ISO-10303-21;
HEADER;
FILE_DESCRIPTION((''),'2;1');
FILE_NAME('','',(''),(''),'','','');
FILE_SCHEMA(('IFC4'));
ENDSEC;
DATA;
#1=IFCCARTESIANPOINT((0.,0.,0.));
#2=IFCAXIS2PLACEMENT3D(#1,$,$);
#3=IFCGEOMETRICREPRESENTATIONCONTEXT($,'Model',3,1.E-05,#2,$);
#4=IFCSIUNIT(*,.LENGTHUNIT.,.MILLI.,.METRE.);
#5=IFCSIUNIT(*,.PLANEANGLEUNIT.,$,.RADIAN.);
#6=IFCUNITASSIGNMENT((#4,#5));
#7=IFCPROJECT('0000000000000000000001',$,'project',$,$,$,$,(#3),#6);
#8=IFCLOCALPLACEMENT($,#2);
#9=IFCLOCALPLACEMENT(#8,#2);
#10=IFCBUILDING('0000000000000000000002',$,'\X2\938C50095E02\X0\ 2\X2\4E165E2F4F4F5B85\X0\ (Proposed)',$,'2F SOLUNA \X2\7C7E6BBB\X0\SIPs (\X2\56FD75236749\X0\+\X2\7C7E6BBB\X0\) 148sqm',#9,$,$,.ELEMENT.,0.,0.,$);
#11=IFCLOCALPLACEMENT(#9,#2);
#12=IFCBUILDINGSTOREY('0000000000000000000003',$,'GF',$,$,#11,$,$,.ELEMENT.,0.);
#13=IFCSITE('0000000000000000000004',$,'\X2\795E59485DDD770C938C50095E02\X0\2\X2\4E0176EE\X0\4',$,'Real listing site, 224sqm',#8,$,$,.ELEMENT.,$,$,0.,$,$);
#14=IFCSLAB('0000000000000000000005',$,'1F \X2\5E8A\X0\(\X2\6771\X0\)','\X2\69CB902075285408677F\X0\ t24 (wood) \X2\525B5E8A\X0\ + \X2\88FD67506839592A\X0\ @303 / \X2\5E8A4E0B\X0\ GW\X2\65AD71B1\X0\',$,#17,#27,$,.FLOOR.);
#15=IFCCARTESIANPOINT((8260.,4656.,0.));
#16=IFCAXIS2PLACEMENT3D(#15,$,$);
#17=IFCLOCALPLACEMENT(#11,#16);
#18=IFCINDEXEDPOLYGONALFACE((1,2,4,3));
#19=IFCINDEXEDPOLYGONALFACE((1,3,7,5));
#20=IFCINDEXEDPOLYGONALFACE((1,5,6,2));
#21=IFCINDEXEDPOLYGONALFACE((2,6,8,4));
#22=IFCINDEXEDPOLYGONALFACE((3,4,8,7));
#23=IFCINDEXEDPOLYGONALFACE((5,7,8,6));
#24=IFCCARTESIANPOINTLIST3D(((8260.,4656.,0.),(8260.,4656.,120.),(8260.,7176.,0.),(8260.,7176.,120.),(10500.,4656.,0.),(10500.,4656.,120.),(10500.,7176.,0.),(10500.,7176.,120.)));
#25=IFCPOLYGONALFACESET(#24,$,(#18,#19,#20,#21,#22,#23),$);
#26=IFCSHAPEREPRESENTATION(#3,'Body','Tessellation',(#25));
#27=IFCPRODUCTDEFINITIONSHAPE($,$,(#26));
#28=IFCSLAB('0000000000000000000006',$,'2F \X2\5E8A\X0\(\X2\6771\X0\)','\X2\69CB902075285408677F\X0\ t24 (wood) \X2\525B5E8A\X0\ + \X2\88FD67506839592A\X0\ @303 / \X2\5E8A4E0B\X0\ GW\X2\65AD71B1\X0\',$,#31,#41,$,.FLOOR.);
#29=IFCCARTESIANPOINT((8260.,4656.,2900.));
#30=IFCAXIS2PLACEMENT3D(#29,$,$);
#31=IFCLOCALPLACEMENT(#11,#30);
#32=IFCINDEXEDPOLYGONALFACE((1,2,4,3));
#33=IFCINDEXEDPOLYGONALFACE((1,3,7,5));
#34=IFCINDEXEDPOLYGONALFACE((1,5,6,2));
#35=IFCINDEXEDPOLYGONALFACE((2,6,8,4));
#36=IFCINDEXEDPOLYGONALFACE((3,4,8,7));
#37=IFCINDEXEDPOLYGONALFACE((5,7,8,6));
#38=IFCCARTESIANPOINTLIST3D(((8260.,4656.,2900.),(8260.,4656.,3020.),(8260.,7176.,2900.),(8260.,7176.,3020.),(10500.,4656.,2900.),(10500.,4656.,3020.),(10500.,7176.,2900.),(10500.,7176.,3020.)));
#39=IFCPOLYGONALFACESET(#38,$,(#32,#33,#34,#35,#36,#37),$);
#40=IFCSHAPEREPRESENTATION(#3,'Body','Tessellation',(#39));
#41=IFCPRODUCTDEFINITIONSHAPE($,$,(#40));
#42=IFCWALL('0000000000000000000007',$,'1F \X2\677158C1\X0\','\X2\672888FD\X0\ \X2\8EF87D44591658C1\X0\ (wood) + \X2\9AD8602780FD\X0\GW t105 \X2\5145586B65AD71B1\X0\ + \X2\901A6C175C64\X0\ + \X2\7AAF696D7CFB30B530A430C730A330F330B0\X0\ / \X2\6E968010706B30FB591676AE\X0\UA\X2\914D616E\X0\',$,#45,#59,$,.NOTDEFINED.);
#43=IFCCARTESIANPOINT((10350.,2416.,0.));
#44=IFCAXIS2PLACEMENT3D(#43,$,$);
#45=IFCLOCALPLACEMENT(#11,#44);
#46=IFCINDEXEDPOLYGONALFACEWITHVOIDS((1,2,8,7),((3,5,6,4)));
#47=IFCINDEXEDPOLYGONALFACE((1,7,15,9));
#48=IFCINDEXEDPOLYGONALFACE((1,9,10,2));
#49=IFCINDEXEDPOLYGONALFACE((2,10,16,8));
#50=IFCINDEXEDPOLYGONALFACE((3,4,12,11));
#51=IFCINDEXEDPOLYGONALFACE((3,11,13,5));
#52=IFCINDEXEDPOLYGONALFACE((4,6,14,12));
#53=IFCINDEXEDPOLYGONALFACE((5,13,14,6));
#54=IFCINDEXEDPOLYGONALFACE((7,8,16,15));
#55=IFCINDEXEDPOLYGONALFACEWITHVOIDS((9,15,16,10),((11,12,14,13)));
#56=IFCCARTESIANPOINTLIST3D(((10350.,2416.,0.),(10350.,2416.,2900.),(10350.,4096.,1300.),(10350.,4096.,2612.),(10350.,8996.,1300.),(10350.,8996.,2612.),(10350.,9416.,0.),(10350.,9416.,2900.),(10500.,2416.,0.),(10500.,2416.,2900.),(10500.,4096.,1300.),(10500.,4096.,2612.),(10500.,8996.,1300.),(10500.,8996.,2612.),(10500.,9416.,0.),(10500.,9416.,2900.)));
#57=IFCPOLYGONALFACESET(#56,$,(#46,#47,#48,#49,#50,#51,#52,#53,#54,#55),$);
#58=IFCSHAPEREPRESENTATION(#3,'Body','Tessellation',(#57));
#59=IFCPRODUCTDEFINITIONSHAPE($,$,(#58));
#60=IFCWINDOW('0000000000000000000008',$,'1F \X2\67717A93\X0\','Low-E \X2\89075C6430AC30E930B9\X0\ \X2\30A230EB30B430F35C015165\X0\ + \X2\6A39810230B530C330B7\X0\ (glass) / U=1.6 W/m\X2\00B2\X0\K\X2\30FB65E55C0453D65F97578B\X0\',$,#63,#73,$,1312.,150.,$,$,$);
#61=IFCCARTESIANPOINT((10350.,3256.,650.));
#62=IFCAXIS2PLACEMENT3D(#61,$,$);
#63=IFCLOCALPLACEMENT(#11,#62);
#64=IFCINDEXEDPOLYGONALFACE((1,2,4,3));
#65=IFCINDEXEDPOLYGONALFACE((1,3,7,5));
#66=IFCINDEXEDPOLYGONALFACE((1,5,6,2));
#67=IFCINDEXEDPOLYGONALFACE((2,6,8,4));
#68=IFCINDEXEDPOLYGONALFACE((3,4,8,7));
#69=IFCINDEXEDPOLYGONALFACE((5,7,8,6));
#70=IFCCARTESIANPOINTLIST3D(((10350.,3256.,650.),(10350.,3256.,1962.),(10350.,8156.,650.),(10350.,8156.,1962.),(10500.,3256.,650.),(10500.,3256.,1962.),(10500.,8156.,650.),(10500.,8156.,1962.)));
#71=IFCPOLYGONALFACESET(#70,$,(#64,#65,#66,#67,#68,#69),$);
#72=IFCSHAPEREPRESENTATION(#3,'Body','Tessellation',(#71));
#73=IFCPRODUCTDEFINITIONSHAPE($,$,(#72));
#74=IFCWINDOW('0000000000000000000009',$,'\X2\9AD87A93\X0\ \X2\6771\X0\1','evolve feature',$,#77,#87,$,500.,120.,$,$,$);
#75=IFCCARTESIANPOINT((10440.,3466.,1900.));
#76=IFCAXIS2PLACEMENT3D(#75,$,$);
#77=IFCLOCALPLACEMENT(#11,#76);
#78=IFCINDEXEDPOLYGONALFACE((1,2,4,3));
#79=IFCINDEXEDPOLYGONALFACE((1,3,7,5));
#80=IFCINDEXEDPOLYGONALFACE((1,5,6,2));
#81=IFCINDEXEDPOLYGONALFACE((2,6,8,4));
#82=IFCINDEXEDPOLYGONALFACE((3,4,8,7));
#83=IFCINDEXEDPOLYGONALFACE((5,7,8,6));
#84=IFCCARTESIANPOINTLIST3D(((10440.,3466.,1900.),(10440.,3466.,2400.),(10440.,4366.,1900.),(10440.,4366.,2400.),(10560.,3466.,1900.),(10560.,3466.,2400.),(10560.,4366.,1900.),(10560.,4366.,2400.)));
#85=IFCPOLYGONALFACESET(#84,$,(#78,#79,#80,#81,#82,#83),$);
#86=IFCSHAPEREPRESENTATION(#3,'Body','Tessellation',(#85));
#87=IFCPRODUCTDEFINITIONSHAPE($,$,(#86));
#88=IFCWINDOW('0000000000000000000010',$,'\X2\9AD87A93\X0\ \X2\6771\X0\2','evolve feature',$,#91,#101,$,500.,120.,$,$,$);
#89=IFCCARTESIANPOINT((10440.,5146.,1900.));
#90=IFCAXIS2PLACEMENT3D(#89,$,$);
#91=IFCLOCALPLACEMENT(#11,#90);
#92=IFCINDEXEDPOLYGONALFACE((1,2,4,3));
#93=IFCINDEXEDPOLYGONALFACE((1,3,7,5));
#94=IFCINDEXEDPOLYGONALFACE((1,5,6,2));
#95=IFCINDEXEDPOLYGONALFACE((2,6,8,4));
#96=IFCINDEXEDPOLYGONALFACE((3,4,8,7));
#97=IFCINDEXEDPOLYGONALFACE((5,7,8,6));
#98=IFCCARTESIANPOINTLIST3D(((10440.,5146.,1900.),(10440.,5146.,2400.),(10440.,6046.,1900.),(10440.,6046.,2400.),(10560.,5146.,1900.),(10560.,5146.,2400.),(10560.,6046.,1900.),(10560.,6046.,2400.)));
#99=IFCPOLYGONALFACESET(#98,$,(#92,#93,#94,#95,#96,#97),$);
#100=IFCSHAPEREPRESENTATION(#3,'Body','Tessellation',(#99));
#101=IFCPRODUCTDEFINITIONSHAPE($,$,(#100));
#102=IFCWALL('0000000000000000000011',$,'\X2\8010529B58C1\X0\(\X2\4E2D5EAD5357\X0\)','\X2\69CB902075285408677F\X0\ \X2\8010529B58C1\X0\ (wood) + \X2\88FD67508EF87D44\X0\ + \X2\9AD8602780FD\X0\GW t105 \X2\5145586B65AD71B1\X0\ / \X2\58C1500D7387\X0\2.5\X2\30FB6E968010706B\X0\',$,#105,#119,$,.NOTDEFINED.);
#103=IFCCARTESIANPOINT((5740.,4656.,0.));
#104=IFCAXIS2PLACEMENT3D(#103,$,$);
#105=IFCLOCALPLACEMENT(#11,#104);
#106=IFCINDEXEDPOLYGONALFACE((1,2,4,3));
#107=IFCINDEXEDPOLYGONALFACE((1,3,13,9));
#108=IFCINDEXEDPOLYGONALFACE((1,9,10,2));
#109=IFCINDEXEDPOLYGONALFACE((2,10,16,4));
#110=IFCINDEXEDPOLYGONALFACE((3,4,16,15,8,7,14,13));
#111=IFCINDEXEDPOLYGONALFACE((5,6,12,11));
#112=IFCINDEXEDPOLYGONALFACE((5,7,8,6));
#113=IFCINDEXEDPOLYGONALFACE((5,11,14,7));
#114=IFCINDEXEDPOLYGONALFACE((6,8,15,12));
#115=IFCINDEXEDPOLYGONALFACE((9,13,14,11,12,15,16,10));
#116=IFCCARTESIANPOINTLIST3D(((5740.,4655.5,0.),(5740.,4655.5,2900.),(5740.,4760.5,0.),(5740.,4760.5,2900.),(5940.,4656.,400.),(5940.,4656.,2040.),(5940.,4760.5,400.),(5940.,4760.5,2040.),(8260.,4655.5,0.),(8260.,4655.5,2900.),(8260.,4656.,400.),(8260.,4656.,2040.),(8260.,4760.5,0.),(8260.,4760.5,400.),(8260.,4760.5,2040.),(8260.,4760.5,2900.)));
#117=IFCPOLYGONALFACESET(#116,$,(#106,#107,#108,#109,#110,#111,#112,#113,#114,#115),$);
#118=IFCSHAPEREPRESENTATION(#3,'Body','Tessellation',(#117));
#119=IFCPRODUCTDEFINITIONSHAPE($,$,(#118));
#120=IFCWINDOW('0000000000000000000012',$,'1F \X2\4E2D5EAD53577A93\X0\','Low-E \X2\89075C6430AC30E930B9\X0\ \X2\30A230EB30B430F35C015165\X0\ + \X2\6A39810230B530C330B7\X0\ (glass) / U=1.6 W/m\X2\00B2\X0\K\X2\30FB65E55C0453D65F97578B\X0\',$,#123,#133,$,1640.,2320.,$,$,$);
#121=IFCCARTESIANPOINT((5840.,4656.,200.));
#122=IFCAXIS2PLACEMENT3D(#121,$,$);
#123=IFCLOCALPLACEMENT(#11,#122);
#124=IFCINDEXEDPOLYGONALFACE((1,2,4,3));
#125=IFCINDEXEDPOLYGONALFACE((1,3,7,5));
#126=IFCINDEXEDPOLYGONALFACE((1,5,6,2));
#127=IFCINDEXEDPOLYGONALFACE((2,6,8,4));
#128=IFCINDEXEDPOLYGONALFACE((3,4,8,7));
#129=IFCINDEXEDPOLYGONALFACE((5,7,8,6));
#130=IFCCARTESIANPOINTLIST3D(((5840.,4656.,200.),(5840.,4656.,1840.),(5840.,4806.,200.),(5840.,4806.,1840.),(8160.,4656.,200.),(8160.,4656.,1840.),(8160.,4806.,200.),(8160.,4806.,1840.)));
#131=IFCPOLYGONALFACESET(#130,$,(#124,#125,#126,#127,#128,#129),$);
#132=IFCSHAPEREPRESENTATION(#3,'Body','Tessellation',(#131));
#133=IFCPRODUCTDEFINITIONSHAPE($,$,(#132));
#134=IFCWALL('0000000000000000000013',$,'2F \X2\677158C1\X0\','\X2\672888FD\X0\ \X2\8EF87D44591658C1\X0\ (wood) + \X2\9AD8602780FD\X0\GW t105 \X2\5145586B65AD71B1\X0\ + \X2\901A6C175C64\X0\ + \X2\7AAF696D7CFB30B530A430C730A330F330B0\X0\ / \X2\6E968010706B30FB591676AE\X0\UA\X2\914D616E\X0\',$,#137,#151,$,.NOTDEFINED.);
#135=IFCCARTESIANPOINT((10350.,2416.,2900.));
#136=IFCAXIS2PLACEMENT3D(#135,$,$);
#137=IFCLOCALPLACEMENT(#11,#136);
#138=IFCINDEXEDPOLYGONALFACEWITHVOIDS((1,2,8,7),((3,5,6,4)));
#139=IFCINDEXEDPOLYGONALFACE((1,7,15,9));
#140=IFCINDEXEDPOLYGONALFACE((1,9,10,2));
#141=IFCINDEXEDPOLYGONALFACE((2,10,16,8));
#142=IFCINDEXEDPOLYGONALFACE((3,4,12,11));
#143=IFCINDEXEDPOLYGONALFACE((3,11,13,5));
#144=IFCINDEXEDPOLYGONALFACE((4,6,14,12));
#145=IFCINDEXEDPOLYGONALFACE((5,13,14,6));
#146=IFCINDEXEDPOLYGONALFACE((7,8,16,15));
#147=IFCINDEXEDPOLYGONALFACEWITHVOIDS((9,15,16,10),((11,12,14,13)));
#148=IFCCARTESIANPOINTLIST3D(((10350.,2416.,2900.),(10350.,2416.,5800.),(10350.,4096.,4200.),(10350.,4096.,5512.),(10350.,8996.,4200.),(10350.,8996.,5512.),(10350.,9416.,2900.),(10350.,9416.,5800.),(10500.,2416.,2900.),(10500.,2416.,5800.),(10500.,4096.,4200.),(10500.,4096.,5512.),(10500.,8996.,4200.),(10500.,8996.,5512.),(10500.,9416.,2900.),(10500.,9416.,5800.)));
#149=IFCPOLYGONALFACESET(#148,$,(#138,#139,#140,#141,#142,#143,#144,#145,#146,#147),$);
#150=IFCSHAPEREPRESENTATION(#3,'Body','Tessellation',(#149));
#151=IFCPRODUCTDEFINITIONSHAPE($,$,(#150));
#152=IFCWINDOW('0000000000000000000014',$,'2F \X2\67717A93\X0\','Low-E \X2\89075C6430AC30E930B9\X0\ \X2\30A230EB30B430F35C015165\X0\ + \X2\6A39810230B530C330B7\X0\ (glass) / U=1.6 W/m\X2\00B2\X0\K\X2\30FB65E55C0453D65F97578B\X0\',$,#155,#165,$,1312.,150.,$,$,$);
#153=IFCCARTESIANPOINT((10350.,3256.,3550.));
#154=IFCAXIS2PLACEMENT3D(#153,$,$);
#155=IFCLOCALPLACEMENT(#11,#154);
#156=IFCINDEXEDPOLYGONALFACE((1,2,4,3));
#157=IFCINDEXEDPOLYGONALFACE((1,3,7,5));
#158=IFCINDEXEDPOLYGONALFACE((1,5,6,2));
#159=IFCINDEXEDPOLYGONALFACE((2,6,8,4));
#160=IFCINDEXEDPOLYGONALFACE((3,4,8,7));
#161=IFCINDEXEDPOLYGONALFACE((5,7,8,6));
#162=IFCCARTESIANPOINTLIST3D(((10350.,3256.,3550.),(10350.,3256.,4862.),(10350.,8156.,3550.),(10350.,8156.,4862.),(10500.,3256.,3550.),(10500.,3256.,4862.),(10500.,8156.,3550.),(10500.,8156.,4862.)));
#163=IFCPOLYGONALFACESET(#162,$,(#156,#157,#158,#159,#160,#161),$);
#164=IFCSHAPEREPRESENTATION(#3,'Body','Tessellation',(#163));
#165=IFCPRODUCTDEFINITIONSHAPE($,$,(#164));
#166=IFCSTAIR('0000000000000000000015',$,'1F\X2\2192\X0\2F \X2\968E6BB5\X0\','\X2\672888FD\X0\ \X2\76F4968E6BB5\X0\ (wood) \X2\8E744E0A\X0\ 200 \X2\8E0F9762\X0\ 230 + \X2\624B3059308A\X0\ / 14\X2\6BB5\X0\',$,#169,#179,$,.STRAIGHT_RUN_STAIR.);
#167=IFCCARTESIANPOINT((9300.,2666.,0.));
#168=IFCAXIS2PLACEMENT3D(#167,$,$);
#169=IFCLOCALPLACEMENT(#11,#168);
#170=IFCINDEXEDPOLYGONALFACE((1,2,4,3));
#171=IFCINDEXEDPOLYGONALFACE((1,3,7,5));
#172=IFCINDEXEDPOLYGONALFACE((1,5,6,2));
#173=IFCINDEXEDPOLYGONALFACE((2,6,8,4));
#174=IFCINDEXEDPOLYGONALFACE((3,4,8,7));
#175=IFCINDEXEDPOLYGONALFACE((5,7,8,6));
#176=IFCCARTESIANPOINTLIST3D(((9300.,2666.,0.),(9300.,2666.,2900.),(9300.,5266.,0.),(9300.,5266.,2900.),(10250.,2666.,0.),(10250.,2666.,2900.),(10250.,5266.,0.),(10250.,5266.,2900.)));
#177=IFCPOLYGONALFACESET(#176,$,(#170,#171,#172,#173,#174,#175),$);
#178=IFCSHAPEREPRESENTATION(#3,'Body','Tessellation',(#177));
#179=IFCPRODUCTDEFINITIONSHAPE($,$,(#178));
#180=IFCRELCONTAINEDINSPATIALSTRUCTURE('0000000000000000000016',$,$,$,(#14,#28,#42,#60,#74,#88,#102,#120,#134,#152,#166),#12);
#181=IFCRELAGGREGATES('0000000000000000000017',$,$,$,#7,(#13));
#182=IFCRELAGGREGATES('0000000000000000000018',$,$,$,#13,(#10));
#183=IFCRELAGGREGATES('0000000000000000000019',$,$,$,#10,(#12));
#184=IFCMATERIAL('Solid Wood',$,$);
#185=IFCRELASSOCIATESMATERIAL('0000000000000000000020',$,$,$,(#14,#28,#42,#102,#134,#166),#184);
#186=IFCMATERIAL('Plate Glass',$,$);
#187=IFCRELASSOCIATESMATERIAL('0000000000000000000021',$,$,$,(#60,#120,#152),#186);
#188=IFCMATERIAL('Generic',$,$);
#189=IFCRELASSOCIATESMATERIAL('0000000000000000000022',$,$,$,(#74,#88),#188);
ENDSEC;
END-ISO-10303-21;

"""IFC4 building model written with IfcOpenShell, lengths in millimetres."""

from ifc_helpers import new_model, si_unit, frame, frame_2d, origin, place, context, project, spatial, rectangle, extrude, material, element, fill, save


model = new_model("IFC4")

# Units and contexts
model_context = context("Model", 3, precision=1e-05, world=origin())
ifc_project = project(units=[si_unit("LENGTHUNIT", "METRE", prefix="MILLI"), si_unit("PLANEANGLEUNIT", "RADIAN")], contexts=[model_context])

# Site, building, storey
site_placement = place(None, origin())
site = spatial("IfcSite", under=ifc_project, at=site_placement, Name="神奈川県鎌倉市2丁目4", ObjectType="Real listing site, 224sqm", CompositionType="ELEMENT", RefElevation=0.0)
building_placement = place(site_placement, origin())
building = spatial("IfcBuilding", under=site, at=building_placement, Name="鎌倉市 2世帯住宅 (Proposed)", ObjectType="2F SOLUNA 籾殻SIPs (国産杉+籾殻) 148sqm", CompositionType="ELEMENT", ElevationOfRefHeight=0.0, ElevationOfTerrain=0.0)
storey_placement = place(building_placement, origin())
storey = spatial("IfcBuildingStorey", under=building, at=storey_placement, Name="GF", CompositionType="ELEMENT", Elevation=0.0)

# Slabs
ifc_material_1 = material(Name="Solid Wood")
slab_1_placement = place(storey_placement, frame((8260.0, 4656.0, 0.0)))
element("IfcSlab", 1, at=slab_1_placement, inside=storey, material=ifc_material_1, Name="1F 床(東)", Description="構造用合板 t24 (wood) 剛床 + 製材根太 @303 / 床下 GW断熱", PredefinedType="FLOOR", context=model_context, shape_type="SweptSolid", body=[
    extrude(rectangle(XDim=2240.0, YDim=2520.0, at=frame_2d((1120.0, 1260.0))), frame((8260.0, 4656.0, 0.0)), (0.0, 0.0, 1.0), 120.0),
])
slab_2_placement = place(storey_placement, frame((8260.0, 4656.0, 2900.0)))
element("IfcSlab", 2, at=slab_2_placement, inside=storey, material=ifc_material_1, Name="2F 床(東)", Description="構造用合板 t24 (wood) 剛床 + 製材根太 @303 / 床下 GW断熱", PredefinedType="FLOOR", context=model_context, shape_type="SweptSolid", body=[
    extrude(rectangle(XDim=2240.0, YDim=2520.0, at=frame_2d((1120.0, 1260.0))), frame((8260.0, 4656.0, 2900.0)), (0.0, 0.0, 1.0), 120.0),
])

# Wall, openings, windows
wall_1_placement = place(storey_placement, frame((10350.0, 2416.0, 0.0)))
wall_1 = element("IfcWall", 3, at=wall_1_placement, inside=storey, material=ifc_material_1, Name="1F 東壁", Description="木製 軸組外壁 (wood) + 高性能GW t105 充填断熱 + 通気層 + 窯業系サイディング / 準耐火・外皮UA配慮", PredefinedType="NOTDEFINED", context=model_context, shape_type="SweptSolid", body=[
    extrude(rectangle(XDim=150.0, YDim=7000.0, at=frame_2d((75.0, 3500.0))), frame((10350.0, 2416.0, 0.0)), (0.0, 0.0, 1.0), 2900.0),
])
opening_1_placement = place(storey_placement, frame((10350.0, 3256.0, 650.0)))
opening_1 = element("IfcOpeningElement", 4, at=opening_1_placement, cuts=wall_1, PredefinedType="NOTDEFINED", context=model_context, shape_type="SweptSolid", body=[
    extrude(rectangle(XDim=150.0, YDim=4900.0, at=frame_2d((75.0, 2450.0))), frame((10350.0, 3256.0, 650.0)), (0.0, 0.0, 1.0), 1312.0),
])
opening_2_placement = place(storey_placement, frame((10440.0, 3466.0, 1900.0)))
opening_2 = element("IfcOpeningElement", 5, at=opening_2_placement, cuts=wall_1, PredefinedType="NOTDEFINED", context=model_context, shape_type="SweptSolid", body=[
    extrude(rectangle(XDim=120.0, YDim=900.0, at=frame_2d((60.0, 450.0))), frame((10440.0, 3466.0, 1900.0)), (0.0, 0.0, 1.0), 500.0),
])
opening_3_placement = place(storey_placement, frame((10440.0, 5146.0, 1900.0)))
opening_3 = element("IfcOpeningElement", 6, at=opening_3_placement, cuts=wall_1, PredefinedType="NOTDEFINED", context=model_context, shape_type="SweptSolid", body=[
    extrude(rectangle(XDim=120.0, YDim=900.0, at=frame_2d((60.0, 450.0))), frame((10440.0, 5146.0, 1900.0)), (0.0, 0.0, 1.0), 500.0),
])
ifc_material_2 = material(Name="Plate Glass")
window_1_placement = place(storey_placement, frame((10350.0, 3256.0, 650.0)))
window_1 = element("IfcWindow", 7, at=window_1_placement, inside=storey, material=ifc_material_2, Name="1F 東窓", Description="Low-E 複層ガラス アルゴン封入 + 樹脂サッシ (glass) / U=1.6 W/m²K・日射取得型", OverallHeight=1312.0, OverallWidth=150.0, context=model_context, shape_type="SweptSolid", body=[
    extrude(rectangle(XDim=150.0, YDim=4900.0, at=frame_2d((75.0, 2450.0))), frame((10350.0, 3256.0, 650.0)), (0.0, 0.0, 1.0), 1312.0),
])
fill(opening_1, window_1)
ifc_material_3 = material(Name="Generic")
window_2_placement = place(storey_placement, frame((10440.0, 3466.0, 1900.0)))
window_2 = element("IfcWindow", 8, at=window_2_placement, inside=storey, material=ifc_material_3, Name="高窓 東1", Description="evolve feature", OverallHeight=500.0, OverallWidth=120.0, context=model_context, shape_type="SweptSolid", body=[
    extrude(rectangle(XDim=120.0, YDim=900.0, at=frame_2d((60.0, 450.0))), frame((10440.0, 3466.0, 1900.0)), (0.0, 0.0, 1.0), 500.0),
])
fill(opening_2, window_2)
window_3_placement = place(storey_placement, frame((10440.0, 5146.0, 1900.0)))
window_3 = element("IfcWindow", 9, at=window_3_placement, inside=storey, material=ifc_material_3, Name="高窓 東2", Description="evolve feature", OverallHeight=500.0, OverallWidth=120.0, context=model_context, shape_type="SweptSolid", body=[
    extrude(rectangle(XDim=120.0, YDim=900.0, at=frame_2d((60.0, 450.0))), frame((10440.0, 5146.0, 1900.0)), (0.0, 0.0, 1.0), 500.0),
])
fill(opening_3, window_3)

# Wall, opening, window
wall_2_placement = place(storey_placement, frame((5740.0, 4656.0, 0.0)))
wall_2 = element("IfcWall", 10, at=wall_2_placement, inside=storey, material=ifc_material_1, Name="耐力壁(中庭南)", Description="構造用合板 耐力壁 (wood) + 製材軸組 + 高性能GW t105 充填断熱 / 壁倍率2.5・準耐火", PredefinedType="NOTDEFINED", context=model_context, shape_type="SweptSolid", body=[
    extrude(rectangle(XDim=2520.0, YDim=105.0, at=frame_2d((1260.0, 52.0))), frame((5740.0, 4656.0, 0.0)), (0.0, 0.0, 1.0), 2900.0),
])
opening_4_placement = place(storey_placement, frame((5840.0, 4656.0, 200.0)))
opening_4 = element("IfcOpeningElement", 11, at=opening_4_placement, cuts=wall_2, PredefinedType="NOTDEFINED", context=model_context, shape_type="SweptSolid", body=[
    extrude(rectangle(XDim=2320.0, YDim=150.0, at=frame_2d((1160.0, 75.0))), frame((5840.0, 4656.0, 200.0)), (0.0, 0.0, 1.0), 1640.0),
])
window_4_placement = place(storey_placement, frame((5840.0, 4656.0, 200.0)))
window_4 = element("IfcWindow", 12, at=window_4_placement, inside=storey, material=ifc_material_2, Name="1F 中庭南窓", Description="Low-E 複層ガラス アルゴン封入 + 樹脂サッシ (glass) / U=1.6 W/m²K・日射取得型", OverallHeight=1640.0, OverallWidth=2320.0, context=model_context, shape_type="SweptSolid", body=[
    extrude(rectangle(XDim=2320.0, YDim=150.0, at=frame_2d((1160.0, 75.0))), frame((5840.0, 4656.0, 200.0)), (0.0, 0.0, 1.0), 1640.0),
])
fill(opening_4, window_4)

# Wall, opening, window
wall_3_placement = place(storey_placement, frame((10350.0, 2416.0, 2900.0)))
wall_3 = element("IfcWall", 13, at=wall_3_placement, inside=storey, material=ifc_material_1, Name="2F 東壁", Description="木製 軸組外壁 (wood) + 高性能GW t105 充填断熱 + 通気層 + 窯業系サイディング / 準耐火・外皮UA配慮", PredefinedType="NOTDEFINED", context=model_context, shape_type="SweptSolid", body=[
    extrude(rectangle(XDim=150.0, YDim=7000.0, at=frame_2d((75.0, 3500.0))), frame((10350.0, 2416.0, 2900.0)), (0.0, 0.0, 1.0), 2900.0),
])
opening_5_placement = place(storey_placement, frame((10350.0, 3256.0, 3550.0)))
opening_5 = element("IfcOpeningElement", 14, at=opening_5_placement, cuts=wall_3, PredefinedType="NOTDEFINED", context=model_context, shape_type="SweptSolid", body=[
    extrude(rectangle(XDim=150.0, YDim=4900.0, at=frame_2d((75.0, 2450.0))), frame((10350.0, 3256.0, 3550.0)), (0.0, 0.0, 1.0), 1312.0),
])
window_5_placement = place(storey_placement, frame((10350.0, 3256.0, 3550.0)))
window_5 = element("IfcWindow", 15, at=window_5_placement, inside=storey, material=ifc_material_2, Name="2F 東窓", Description="Low-E 複層ガラス アルゴン封入 + 樹脂サッシ (glass) / U=1.6 W/m²K・日射取得型", OverallHeight=1312.0, OverallWidth=150.0, context=model_context, shape_type="SweptSolid", body=[
    extrude(rectangle(XDim=150.0, YDim=4900.0, at=frame_2d((75.0, 2450.0))), frame((10350.0, 3256.0, 3550.0)), (0.0, 0.0, 1.0), 1312.0),
])
fill(opening_5, window_5)

# Stair
stair_placement = place(storey_placement, frame((9300.0, 2666.0, 0.0)))
element("IfcStair", 16, at=stair_placement, inside=storey, material=ifc_material_1, Name="1F→2F 階段", Description="木製 直階段 (wood) 蹴上 200 踏面 230 + 手すり / 14段", PredefinedType="STRAIGHT_RUN_STAIR", context=model_context, shape_type="SweptSolid", body=[
    extrude(rectangle(XDim=950.0, YDim=2600.0, at=frame_2d((475.0, 1300.0))), frame((9300.0, 2666.0, 0.0)), (0.0, 0.0, 1.0), 2900.0),
])

save(model, "model.ifc")
